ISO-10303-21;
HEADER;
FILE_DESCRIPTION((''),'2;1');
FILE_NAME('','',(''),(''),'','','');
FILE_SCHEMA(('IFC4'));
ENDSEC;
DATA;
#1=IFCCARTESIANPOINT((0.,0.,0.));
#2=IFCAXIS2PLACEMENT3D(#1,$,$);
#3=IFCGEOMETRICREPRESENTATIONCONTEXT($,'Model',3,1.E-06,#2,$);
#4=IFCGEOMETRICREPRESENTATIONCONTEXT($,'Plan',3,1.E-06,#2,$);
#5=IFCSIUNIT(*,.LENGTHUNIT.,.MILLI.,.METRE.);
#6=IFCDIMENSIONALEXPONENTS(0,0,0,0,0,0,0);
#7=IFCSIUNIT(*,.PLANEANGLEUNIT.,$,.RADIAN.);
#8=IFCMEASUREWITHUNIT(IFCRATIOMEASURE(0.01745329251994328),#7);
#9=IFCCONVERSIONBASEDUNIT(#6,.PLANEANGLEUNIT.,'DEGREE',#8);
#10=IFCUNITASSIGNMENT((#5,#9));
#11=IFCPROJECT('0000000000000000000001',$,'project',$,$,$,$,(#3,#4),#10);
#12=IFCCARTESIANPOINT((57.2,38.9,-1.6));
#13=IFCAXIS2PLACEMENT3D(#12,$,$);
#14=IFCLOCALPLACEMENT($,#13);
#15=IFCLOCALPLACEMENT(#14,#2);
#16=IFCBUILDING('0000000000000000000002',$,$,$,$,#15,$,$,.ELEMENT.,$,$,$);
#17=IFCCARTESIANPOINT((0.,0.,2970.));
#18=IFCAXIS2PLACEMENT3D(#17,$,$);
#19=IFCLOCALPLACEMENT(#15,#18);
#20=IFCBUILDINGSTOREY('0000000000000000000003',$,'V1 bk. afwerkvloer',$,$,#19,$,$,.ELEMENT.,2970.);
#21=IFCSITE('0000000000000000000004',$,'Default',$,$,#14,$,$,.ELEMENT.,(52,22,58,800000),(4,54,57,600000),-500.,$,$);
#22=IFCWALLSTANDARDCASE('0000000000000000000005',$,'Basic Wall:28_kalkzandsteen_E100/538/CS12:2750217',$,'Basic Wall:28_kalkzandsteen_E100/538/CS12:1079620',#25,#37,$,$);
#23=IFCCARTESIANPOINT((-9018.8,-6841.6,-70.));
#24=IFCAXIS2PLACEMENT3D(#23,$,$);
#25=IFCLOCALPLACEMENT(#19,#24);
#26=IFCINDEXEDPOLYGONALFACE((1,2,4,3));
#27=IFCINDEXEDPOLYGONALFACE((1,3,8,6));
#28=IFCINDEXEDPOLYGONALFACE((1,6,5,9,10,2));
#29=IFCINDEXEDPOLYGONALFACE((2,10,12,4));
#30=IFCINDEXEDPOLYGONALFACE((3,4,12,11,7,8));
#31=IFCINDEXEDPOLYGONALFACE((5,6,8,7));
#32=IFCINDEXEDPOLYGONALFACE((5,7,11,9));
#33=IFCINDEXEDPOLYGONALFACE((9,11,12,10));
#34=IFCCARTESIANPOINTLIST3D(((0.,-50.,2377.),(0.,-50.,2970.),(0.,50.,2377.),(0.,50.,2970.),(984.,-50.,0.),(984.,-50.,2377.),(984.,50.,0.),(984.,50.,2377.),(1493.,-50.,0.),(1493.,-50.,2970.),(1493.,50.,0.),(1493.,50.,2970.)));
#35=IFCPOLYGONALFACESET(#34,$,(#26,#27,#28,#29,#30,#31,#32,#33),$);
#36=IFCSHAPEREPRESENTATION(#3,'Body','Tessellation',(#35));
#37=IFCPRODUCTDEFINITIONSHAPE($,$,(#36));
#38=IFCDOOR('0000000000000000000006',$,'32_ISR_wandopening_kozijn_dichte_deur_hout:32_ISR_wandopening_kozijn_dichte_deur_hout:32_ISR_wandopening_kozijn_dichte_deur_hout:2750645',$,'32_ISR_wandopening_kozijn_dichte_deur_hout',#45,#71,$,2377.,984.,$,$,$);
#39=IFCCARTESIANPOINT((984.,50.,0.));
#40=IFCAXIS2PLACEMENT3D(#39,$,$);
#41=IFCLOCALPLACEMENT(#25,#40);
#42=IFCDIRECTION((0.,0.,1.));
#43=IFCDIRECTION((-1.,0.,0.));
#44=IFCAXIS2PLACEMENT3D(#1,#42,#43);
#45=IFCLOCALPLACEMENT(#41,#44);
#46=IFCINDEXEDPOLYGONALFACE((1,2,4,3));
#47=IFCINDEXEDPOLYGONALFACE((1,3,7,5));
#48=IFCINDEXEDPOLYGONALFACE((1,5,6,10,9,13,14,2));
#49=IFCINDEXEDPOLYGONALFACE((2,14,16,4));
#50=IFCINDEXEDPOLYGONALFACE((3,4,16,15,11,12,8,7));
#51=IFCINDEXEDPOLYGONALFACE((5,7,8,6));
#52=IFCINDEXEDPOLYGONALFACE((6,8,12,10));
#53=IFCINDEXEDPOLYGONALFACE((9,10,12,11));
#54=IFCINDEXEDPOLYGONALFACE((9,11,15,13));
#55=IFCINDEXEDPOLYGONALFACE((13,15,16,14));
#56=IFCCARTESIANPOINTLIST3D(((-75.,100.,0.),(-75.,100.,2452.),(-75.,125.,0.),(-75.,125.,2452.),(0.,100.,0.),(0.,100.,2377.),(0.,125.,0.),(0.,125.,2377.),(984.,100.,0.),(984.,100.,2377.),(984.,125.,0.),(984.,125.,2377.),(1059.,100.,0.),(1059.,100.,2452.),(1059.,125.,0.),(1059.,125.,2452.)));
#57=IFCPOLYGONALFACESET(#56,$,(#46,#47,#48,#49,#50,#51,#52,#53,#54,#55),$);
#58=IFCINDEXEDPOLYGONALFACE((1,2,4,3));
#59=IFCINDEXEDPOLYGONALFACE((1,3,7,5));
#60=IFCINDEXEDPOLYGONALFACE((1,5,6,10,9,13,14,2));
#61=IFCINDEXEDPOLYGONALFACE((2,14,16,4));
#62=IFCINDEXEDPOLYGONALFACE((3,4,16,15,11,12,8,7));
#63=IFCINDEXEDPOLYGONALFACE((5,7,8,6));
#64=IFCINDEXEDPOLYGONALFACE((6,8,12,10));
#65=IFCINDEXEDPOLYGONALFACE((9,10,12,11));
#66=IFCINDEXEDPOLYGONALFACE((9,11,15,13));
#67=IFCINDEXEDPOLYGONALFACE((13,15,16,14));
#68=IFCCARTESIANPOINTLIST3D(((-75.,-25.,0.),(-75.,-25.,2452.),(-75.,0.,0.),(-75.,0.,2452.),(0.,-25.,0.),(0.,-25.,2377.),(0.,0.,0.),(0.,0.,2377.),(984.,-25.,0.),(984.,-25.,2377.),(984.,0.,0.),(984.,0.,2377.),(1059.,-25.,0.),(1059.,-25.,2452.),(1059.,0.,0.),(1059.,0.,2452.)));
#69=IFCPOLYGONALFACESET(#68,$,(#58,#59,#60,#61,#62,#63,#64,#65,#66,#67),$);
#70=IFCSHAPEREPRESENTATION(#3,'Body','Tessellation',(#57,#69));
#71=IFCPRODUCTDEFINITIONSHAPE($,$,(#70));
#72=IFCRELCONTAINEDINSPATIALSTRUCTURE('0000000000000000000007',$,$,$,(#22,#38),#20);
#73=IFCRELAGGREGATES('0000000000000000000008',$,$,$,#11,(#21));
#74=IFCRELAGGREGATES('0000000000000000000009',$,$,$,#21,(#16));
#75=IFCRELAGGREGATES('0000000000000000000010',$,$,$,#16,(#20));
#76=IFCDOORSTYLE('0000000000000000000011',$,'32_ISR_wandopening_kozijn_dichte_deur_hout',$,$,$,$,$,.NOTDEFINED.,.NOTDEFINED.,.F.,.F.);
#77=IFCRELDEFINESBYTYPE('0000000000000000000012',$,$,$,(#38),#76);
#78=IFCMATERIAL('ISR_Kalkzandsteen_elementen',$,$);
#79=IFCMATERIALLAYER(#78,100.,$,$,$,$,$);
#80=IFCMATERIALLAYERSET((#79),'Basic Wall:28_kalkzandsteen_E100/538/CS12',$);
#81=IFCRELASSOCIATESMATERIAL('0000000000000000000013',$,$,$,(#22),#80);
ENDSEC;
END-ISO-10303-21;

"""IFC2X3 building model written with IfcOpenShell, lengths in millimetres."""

from ifc_helpers import new_model, entity, si_unit, converted_unit, frame, frame_2d, origin, place, context, project, spatial, polyline, rectangle, outline, extrude, source, transform, mapped, material, layer, layer_set, layer_usage, type_object, type_shapes, element, fill, save


model = new_model("IFC2X3")

# Units and contexts
model_context = context("Model", 3, precision=1e-06, world=origin())
plan_context = context("Plan", 3, precision=1e-06, world=origin())
ifc_project = project(units=[si_unit("LENGTHUNIT", "METRE", prefix="MILLI"), converted_unit("PLANEANGLEUNIT", "DEGREE", entity("IfcRatioMeasure", 0.01745329251994328), si_unit("PLANEANGLEUNIT", "RADIAN"), dimensions=[0, 0, 0, 0, 0, 0, 0])], contexts=[model_context, plan_context])

# Site, building, storey
site_placement = place(None, frame((57.2, 38.9, -1.6)))
site = spatial("IfcSite", under=ifc_project, at=site_placement, Name="Default", CompositionType="ELEMENT", RefLatitude=(52, 22, 58, 800000), RefLongitude=(4, 54, 57, 600000), RefElevation=-500.0)
building_placement = place(site_placement, origin())
building = spatial("IfcBuilding", under=site, at=building_placement, CompositionType="ELEMENT")
storey_placement = place(building_placement, frame((0.0, 0.0, 2970.0)))
storey = spatial("IfcBuildingStorey", under=building, at=storey_placement, Name="V1 bk. afwerkvloer", CompositionType="ELEMENT", Elevation=2970.0)

# Shared definitions
ifc_material_1 = material(Name="ISR_Kalkzandsteen_elementen")
ifc_layer_1 = layer(ifc_material_1, 100.0)
ifc_layer_set_1 = layer_set([ifc_layer_1], Name="Basic Wall:28_kalkzandsteen_E100/538/CS12")

# Shared definitions
door_style_1 = type_object("IfcDoorStyle", Name="32_ISR_wandopening_kozijn_dichte_deur_hout", ConstructionType="NOTDEFINED", OperationType="NOTDEFINED", ParameterTakesPrecedence=False, Sizeable=False)
shared_shape_1 = source(origin(), model_context, "Body", "SweptSolid", [
    extrude(outline(polyline([(-1169.7, 492.0), (1207.2, 492.0), (1207.2, 567.0), (-1244.7, 567.0), (-1244.7, -567.0), (1207.2, -567.0), (1207.2, -492.0), (-1169.7, -492.0), (-1169.7, 492.0)])), frame((492.0, 100.0, 1207.2), z_axis=(0.0, 1.0, 0.0), x_axis=(0.0, 0.0, -1.0)), (0.0, 0.0, 1.0), 25.0),
    extrude(outline(polyline([(-567.0, -1244.7), (567.0, -1244.7), (567.0, 1207.2), (492.0, 1207.2), (492.0, -1169.7), (-492.0, -1169.7), (-492.0, 1207.2), (-567.0, 1207.2), (-567.0, -1244.7)])), frame((492.0, -25.0, 1207.2), z_axis=(0.0, 1.0, 0.0), x_axis=(1.0, 0.0, 0.0)), (0.0, 0.0, 1.0), 25.0),
])
type_shapes(door_style_1, [shared_shape_1])

# Wall, opening, door
ifc_layer_usage_1 = layer_usage(ifc_layer_set_1, "AXIS2", "NEGATIVE", 50.0)
wall_1_placement = place(storey_placement, frame((-9018.8, -6841.6, -70.0)))
wall_1 = element("IfcWallStandardCase", 1, at=wall_1_placement, inside=storey, material=ifc_layer_usage_1, Name="Basic Wall:28_kalkzandsteen_E100/538/CS12:2750217", ObjectType="Basic Wall:28_kalkzandsteen_E100/538/CS12:1079620", context=model_context, shape_type="SweptSolid", body=[
    extrude(rectangle(XDim=1493.0, YDim=100.0, at=frame_2d((746.5, 0.0), x_axis=(-1.0, 0.0))), origin(), (0.0, 0.0, 1.0), 2970.0),
])
opening_1_placement = place(wall_1_placement, frame((984.0, 50.0, 0.0)))
opening_1 = element("IfcOpeningElement", 2, at=opening_1_placement, cuts=wall_1, ObjectType="Opening", context=model_context, shape_type="SweptSolid", body=[
    extrude(rectangle(XDim=2377.0, YDim=984.0, at=frame_2d((1188.5, 492.0), x_axis=(1.0, 0.0))), frame((0.0, 0.0, 0.0), z_axis=(0.0, -1.0, 0.0), x_axis=(0.0, 0.0, 1.0)), (0.0, 0.0, 1.0), 100.0),
])
door_1_placement = place(opening_1_placement, frame((0.0, 0.0, 0.0), z_axis=(0.0, 0.0, 1.0), x_axis=(-1.0, 0.0, 0.0)))
door_1 = element("IfcDoor", 3, at=door_1_placement, inside=storey, type_object=door_style_1, Name="32_ISR_wandopening_kozijn_dichte_deur_hout:32_ISR_wandopening_kozijn_dichte_deur_hout:32_ISR_wandopening_kozijn_dichte_deur_hout:2750645", ObjectType="32_ISR_wandopening_kozijn_dichte_deur_hout", OverallHeight=2377.0, OverallWidth=984.0, context=model_context, shape_type="MappedRepresentation", body=[
    mapped(shared_shape_1, transform((0.0, 0.0, 0.0), scale=1.0)),
])
fill(opening_1, door_1)

save(model, "model.ifc")
